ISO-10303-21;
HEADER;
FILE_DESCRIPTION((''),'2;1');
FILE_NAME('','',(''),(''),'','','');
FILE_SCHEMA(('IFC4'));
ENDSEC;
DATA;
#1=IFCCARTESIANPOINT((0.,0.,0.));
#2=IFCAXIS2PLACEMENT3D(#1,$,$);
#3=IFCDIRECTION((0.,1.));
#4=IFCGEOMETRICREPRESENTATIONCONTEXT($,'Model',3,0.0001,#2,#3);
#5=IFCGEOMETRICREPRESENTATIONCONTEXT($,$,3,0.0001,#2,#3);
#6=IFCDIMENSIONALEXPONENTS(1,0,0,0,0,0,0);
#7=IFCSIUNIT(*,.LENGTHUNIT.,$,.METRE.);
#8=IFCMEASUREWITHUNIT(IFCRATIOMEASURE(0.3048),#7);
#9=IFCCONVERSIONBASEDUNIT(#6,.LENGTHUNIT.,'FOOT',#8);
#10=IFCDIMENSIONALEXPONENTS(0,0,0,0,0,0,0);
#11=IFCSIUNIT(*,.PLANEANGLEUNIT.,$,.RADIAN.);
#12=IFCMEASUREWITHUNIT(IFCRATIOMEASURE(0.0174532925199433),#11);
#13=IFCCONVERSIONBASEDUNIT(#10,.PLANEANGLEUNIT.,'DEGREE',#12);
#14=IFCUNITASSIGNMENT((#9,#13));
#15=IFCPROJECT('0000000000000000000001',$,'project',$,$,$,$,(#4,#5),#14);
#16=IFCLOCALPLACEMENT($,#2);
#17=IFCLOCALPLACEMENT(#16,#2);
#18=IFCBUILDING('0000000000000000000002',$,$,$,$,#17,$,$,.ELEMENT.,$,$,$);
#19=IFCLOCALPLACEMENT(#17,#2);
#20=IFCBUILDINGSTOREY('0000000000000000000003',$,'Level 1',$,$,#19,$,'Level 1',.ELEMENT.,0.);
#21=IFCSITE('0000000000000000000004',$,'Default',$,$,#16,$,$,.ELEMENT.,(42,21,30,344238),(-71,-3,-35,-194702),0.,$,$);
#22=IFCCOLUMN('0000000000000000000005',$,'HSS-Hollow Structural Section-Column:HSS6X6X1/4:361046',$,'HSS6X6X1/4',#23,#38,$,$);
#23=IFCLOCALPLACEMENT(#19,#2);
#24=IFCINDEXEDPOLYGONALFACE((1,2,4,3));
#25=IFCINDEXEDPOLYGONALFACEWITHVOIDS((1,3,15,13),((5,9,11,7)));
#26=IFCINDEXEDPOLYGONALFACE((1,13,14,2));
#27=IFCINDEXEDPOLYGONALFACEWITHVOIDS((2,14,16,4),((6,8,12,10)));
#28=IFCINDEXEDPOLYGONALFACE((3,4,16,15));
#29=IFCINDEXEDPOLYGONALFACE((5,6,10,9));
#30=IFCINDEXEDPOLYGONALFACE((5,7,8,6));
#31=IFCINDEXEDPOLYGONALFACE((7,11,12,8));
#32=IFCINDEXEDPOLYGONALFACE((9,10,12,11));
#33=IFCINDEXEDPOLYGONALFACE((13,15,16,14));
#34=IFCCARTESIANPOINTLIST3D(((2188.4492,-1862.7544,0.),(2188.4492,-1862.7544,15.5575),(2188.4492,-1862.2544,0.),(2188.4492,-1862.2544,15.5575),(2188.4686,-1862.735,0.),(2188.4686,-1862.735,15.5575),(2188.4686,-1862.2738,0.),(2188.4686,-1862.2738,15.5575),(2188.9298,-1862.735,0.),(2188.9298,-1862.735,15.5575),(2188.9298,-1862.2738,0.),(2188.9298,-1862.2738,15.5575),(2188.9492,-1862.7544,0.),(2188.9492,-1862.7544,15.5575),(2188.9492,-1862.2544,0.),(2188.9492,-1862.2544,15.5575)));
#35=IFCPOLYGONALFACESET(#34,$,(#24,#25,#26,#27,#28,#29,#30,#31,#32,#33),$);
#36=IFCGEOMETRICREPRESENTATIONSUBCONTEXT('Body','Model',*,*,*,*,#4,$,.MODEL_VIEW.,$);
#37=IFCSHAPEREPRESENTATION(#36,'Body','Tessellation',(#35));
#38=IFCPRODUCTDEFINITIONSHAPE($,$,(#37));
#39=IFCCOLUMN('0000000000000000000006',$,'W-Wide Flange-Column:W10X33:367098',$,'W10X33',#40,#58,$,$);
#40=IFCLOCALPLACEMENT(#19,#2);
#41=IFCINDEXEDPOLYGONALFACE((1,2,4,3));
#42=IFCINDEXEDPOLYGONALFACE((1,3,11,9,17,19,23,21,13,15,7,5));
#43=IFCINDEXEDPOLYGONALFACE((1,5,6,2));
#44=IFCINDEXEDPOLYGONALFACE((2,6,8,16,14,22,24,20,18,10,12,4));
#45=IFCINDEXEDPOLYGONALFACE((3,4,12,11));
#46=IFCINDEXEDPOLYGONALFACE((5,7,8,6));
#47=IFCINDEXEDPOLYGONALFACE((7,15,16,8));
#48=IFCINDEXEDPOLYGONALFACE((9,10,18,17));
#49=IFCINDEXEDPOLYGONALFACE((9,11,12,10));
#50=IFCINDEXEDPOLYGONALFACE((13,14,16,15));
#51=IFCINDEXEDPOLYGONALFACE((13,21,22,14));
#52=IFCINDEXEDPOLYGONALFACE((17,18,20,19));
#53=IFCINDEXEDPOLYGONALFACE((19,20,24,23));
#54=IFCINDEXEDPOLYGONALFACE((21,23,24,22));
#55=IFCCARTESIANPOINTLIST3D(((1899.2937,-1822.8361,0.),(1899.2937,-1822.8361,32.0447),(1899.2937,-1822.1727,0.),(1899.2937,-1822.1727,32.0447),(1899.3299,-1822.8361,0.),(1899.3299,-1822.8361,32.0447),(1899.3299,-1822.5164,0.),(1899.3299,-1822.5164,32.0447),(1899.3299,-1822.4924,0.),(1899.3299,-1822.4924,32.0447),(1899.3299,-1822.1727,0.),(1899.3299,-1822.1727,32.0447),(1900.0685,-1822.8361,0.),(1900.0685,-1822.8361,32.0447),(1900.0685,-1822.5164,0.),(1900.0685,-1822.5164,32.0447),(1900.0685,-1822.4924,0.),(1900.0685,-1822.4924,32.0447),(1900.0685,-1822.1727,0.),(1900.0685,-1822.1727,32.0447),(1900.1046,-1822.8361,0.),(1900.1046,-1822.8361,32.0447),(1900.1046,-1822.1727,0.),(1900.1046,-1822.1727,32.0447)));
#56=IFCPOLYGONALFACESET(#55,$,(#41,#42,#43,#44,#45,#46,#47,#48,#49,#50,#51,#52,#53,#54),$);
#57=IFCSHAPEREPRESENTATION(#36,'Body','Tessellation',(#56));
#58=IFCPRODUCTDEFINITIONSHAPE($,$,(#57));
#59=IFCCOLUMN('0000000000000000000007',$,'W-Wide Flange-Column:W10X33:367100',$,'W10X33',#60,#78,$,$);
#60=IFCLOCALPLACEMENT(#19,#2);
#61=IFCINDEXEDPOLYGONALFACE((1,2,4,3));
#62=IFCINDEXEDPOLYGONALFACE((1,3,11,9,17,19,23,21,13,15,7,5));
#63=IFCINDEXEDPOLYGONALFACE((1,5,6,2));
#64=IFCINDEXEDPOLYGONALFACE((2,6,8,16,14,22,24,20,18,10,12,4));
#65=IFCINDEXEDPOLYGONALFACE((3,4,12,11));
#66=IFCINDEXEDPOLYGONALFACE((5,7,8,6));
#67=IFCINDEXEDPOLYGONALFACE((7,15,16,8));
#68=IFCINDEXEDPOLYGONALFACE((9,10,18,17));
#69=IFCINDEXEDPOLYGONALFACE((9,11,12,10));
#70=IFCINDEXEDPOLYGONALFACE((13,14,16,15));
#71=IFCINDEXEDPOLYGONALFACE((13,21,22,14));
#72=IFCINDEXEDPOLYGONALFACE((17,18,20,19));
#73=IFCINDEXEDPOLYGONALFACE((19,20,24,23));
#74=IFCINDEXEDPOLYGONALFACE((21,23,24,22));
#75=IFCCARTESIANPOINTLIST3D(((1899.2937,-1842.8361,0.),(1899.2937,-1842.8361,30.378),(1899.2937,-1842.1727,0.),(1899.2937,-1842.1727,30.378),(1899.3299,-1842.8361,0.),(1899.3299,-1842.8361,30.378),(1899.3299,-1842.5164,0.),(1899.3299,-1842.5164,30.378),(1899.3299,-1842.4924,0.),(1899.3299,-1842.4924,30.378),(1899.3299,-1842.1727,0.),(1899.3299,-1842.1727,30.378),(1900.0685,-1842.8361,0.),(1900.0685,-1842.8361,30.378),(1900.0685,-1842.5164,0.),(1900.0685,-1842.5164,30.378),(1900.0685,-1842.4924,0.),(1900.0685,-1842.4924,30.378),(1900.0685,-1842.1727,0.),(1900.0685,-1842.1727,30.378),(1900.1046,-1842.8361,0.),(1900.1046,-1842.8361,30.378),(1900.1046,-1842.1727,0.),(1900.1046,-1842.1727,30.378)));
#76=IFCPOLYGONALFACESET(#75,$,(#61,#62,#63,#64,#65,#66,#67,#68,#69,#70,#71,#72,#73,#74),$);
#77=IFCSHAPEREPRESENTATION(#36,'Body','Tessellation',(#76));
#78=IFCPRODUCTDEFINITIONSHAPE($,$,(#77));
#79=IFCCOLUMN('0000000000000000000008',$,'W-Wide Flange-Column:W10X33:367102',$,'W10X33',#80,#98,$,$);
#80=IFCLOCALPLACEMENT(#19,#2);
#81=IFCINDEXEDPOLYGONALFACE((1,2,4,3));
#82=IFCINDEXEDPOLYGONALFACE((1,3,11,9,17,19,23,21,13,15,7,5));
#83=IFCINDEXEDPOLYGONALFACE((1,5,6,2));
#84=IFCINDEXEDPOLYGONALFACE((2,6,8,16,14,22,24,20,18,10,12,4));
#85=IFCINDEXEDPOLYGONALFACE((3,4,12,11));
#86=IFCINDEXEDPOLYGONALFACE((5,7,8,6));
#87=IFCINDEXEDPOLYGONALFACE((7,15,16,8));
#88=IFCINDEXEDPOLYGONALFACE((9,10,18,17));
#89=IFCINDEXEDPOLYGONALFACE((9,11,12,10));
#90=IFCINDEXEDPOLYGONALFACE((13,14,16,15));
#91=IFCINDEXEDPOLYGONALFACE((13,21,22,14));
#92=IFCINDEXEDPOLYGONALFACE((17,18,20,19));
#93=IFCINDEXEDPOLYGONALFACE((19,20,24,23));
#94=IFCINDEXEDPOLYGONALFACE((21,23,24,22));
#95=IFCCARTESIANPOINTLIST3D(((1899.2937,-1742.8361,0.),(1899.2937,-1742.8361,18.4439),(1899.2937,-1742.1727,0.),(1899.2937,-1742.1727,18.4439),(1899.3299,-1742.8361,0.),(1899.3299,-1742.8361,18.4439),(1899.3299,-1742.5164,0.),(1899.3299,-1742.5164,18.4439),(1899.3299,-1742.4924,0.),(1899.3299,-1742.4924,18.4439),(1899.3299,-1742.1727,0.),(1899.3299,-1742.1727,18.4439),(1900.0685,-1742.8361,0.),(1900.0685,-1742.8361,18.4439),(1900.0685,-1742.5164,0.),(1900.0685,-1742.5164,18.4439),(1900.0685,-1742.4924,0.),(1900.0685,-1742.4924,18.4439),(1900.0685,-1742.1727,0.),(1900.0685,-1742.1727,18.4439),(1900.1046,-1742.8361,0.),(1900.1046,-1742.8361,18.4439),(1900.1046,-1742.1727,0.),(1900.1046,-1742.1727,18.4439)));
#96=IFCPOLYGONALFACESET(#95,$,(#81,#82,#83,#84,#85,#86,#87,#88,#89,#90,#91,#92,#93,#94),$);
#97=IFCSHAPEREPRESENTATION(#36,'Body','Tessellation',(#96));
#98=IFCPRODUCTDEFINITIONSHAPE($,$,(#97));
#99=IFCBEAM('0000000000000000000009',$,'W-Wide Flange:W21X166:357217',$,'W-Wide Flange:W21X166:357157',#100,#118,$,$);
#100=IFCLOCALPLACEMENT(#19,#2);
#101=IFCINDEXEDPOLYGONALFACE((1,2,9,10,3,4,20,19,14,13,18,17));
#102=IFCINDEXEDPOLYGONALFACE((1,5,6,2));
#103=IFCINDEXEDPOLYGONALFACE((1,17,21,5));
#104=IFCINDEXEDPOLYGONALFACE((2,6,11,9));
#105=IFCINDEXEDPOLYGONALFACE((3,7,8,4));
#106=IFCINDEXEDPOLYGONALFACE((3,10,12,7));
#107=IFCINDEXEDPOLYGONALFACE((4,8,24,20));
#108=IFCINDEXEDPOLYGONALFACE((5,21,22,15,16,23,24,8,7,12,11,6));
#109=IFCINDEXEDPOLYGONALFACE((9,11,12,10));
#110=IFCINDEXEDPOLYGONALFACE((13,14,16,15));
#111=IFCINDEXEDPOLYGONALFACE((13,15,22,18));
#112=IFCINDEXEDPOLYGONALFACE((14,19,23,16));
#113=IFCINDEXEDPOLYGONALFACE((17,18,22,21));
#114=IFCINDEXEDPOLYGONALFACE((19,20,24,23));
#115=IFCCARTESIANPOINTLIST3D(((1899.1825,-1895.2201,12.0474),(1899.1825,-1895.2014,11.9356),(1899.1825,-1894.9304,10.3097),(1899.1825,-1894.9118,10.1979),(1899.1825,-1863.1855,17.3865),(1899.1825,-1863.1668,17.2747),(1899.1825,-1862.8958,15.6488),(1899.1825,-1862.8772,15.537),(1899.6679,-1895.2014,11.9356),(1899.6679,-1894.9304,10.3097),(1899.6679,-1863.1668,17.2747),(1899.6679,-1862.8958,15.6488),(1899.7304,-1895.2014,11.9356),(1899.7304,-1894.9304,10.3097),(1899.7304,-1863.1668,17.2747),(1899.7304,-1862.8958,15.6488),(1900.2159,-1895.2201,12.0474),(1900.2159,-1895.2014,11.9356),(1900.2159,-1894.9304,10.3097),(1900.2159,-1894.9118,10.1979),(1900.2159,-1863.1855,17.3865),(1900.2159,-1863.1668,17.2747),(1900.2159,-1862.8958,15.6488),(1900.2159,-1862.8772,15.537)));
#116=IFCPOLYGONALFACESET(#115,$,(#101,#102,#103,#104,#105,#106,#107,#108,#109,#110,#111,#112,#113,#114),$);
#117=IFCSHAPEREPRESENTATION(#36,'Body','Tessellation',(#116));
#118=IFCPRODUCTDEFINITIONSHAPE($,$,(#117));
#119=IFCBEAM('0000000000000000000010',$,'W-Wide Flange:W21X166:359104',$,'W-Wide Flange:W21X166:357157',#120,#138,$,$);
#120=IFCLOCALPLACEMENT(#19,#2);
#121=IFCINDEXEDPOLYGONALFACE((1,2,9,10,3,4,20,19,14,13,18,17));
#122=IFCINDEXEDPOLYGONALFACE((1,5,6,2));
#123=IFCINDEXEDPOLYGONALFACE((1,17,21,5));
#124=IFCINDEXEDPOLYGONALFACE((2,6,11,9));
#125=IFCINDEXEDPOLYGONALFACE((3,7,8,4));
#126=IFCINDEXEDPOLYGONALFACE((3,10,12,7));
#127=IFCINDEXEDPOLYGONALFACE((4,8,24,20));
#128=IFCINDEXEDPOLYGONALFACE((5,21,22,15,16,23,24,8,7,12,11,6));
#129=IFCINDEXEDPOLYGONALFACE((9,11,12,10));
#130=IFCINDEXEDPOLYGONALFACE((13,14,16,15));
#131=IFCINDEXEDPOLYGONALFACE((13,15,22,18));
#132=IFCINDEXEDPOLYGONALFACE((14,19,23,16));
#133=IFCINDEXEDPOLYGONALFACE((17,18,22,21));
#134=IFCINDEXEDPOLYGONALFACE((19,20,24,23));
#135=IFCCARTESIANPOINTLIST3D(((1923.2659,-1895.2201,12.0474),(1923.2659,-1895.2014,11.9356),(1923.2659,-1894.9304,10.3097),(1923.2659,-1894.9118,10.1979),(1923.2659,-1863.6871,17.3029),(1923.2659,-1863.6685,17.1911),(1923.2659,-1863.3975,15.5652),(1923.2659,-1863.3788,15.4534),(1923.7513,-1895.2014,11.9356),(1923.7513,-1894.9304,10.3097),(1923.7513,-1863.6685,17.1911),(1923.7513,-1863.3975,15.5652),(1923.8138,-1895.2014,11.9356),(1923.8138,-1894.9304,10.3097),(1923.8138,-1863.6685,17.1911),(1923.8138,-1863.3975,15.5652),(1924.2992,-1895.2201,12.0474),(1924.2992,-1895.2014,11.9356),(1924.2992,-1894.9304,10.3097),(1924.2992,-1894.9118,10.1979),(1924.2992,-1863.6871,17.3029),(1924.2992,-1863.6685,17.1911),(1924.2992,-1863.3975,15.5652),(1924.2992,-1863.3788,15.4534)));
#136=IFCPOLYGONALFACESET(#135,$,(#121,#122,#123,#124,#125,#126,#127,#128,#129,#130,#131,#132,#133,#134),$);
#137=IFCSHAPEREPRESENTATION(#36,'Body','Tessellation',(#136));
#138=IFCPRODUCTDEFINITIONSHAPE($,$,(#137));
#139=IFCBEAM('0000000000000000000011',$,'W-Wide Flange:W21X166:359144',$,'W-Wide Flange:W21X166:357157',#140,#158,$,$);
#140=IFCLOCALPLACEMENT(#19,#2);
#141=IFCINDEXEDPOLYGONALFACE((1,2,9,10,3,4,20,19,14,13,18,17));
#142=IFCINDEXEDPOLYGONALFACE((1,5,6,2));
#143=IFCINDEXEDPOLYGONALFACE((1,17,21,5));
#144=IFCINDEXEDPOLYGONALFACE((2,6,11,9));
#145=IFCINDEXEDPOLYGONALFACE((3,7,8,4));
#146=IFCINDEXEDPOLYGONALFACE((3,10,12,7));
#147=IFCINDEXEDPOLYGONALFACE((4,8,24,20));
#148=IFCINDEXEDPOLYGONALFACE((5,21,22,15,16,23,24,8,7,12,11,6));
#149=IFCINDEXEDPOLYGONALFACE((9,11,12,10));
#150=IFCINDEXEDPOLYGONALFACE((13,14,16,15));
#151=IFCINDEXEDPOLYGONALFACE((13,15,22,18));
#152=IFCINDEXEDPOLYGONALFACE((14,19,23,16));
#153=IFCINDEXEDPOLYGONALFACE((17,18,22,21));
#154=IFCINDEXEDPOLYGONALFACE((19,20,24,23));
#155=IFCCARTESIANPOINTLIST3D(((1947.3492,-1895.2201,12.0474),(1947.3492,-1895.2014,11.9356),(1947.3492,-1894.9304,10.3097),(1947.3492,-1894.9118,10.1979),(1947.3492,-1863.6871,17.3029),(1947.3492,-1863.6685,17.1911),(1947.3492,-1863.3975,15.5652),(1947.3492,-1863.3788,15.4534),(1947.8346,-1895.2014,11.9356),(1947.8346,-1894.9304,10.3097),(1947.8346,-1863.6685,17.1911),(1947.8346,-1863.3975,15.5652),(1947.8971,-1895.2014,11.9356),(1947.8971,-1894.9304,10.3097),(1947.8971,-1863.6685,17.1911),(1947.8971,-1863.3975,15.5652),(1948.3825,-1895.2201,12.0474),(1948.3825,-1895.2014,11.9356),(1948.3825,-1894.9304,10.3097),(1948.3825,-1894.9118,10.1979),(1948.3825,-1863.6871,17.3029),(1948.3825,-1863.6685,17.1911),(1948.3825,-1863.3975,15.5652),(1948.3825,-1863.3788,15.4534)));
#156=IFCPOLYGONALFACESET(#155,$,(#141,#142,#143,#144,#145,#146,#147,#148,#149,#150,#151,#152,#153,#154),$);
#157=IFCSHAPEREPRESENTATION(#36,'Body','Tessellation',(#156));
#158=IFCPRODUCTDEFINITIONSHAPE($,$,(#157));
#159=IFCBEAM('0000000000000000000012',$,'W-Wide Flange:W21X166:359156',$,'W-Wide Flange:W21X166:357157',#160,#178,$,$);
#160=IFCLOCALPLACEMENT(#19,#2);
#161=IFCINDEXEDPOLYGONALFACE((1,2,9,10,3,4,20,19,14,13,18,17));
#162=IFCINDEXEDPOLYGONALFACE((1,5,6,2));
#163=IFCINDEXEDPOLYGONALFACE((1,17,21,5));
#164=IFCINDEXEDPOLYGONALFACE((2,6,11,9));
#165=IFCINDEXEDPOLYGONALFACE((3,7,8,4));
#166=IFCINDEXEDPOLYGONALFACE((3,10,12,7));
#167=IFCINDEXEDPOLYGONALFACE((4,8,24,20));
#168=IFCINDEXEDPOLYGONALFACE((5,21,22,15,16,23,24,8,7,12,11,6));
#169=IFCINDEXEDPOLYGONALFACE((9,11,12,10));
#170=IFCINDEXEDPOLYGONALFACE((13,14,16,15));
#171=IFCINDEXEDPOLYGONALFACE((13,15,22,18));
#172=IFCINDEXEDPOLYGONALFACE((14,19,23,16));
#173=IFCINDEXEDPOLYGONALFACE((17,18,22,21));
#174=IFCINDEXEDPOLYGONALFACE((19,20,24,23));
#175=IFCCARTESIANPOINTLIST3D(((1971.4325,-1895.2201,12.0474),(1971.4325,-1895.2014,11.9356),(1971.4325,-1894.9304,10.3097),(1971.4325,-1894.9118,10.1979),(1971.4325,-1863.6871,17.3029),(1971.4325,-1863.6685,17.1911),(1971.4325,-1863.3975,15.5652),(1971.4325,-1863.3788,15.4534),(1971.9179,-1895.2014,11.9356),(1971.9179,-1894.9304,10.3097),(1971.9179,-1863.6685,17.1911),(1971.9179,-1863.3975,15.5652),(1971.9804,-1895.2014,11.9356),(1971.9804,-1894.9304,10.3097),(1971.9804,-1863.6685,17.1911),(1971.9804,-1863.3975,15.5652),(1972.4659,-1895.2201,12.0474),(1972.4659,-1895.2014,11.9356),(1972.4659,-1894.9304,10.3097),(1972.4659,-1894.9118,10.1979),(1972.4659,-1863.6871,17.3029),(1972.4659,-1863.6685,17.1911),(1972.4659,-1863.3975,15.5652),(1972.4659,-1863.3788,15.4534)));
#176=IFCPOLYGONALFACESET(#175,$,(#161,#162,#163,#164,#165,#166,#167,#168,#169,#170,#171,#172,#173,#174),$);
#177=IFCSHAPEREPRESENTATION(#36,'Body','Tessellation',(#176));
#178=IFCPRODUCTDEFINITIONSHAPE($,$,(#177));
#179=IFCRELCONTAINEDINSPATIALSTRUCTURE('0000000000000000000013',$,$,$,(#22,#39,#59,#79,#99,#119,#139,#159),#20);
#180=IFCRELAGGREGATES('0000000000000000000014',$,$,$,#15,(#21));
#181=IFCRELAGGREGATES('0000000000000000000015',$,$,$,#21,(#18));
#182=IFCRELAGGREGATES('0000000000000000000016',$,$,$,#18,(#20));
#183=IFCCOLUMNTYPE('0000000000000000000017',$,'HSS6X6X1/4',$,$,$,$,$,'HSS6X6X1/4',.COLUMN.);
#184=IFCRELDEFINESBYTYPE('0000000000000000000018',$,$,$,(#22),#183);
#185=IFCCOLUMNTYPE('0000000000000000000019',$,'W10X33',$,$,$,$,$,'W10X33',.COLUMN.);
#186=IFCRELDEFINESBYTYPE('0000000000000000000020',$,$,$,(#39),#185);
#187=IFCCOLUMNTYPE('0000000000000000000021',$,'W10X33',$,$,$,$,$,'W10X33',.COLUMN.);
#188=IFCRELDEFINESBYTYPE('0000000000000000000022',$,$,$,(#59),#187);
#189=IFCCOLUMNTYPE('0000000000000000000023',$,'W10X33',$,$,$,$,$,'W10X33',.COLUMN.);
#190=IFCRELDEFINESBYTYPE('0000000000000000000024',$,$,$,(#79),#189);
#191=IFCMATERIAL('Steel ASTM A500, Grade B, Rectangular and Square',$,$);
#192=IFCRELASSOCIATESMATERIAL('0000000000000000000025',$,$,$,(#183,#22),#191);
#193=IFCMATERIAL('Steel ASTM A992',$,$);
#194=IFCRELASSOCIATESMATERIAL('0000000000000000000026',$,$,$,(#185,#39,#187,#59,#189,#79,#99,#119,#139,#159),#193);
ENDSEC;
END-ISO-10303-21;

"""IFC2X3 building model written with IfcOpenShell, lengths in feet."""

from ifc_helpers import new_model, entity, si_unit, converted_unit, direction, frame, frame_2d, origin, place, context, subcontext, project, spatial, polyline, i_section, outline, extrude, source, transform, mapped, material, type_object, type_shapes, element, save


model = new_model("IFC2X3")

# Units and contexts
model_context = context("Model", 3, precision=0.0001, world=origin(), true_north=direction((0.0, 1.0)))
context_of_model = context(None, 3, precision=0.0001, world=origin(), true_north=direction((0.0, 1.0)))
body_context = subcontext(model_context, "Body", "Model", "MODEL_VIEW")
ifc_project = project(units=[converted_unit("LENGTHUNIT", "FOOT", entity("IfcRatioMeasure", 0.3048), si_unit("LENGTHUNIT", "METRE"), dimensions=[1, 0, 0, 0, 0, 0, 0]), converted_unit("PLANEANGLEUNIT", "DEGREE", entity("IfcRatioMeasure", 0.0174532925199433), si_unit("PLANEANGLEUNIT", "RADIAN"), dimensions=[0, 0, 0, 0, 0, 0, 0])], contexts=[model_context, context_of_model])

# Site, building, storey
site_placement = place(None, origin())
site = spatial("IfcSite", under=ifc_project, at=site_placement, Name="Default", CompositionType="ELEMENT", RefLatitude=(42, 21, 30, 344238), RefLongitude=(-71, -3, -35, -194702), RefElevation=0.0)
building_placement = place(site_placement, origin())
building = spatial("IfcBuilding", under=site, at=building_placement, CompositionType="ELEMENT")
storey_placement = place(building_placement, origin())
storey = spatial("IfcBuildingStorey", under=building, at=storey_placement, Name="Level 1", LongName="Level 1", CompositionType="ELEMENT", Elevation=0.0)

# Columns
ifc_material_1 = material(Name="Steel ASTM A500, Grade B, Rectangular and Square")
column_type_1 = type_object("IfcColumnType", Name="HSS6X6X1/4", ElementType="HSS6X6X1/4", PredefinedType="COLUMN", material=ifc_material_1)
shared_shape_1 = source(origin(), body_context, "Body", "SweptSolid", [
    extrude(outline(polyline([(-0.25, -0.25), (0.25, -0.25), (0.25, 0.25), (-0.25, 0.25), (-0.25, -0.25)]), holes=[polyline([(-0.2306, -0.2306), (-0.2306, 0.2306), (0.2306, 0.2306), (0.2306, -0.2306), (-0.2306, -0.2306)])]), frame((0.25, 0.25, 0.0), z_axis=(0.0, 0.0, 1.0), x_axis=(-1.0, 0.0, 0.0)), (0.0, 0.0, 1.0), 15.5575),
])
type_shapes(column_type_1, [shared_shape_1])
column_1_placement = place(storey_placement, frame((2188.4492, -1862.7544, 0.0)))
element("IfcColumn", 1, at=column_1_placement, inside=storey, type_object=column_type_1, material=ifc_material_1, Name="HSS-Hollow Structural Section-Column:HSS6X6X1/4:361046", ObjectType="HSS6X6X1/4", context=body_context, shape_type="MappedRepresentation", body=[
    mapped(shared_shape_1, transform((0.0, 0.0, 0.0), scale=1.0)),
])
ifc_material_2 = material(Name="Steel ASTM A992")
column_type_2 = type_object("IfcColumnType", Name="W10X33", ElementType="W10X33", PredefinedType="COLUMN", material=ifc_material_2)
shared_shape_2 = source(origin(), body_context, "Body", "SweptSolid", [
    extrude(i_section(OverallWidth=0.6634, OverallDepth=0.8109, WebThickness=0.0241, FlangeThickness=0.0361, at=frame_2d((0.0, 0.0), x_axis=(1.0, 0.0))), frame((0.4054, 0.3317, 0.0), z_axis=(0.0, 0.0, 1.0), x_axis=(0.0, 1.0, 0.0)), (0.0, 0.0, 1.0), 32.0447),
])
type_shapes(column_type_2, [shared_shape_2])
column_2_placement = place(storey_placement, frame((1899.2937, -1822.8361, 0.0)))
element("IfcColumn", 2, at=column_2_placement, inside=storey, type_object=column_type_2, material=ifc_material_2, Name="W-Wide Flange-Column:W10X33:367098", ObjectType="W10X33", context=body_context, shape_type="MappedRepresentation", body=[
    mapped(shared_shape_2, transform((0.0, 0.0, 0.0), scale=1.0)),
])
column_type_3 = type_object("IfcColumnType", Name="W10X33", ElementType="W10X33", PredefinedType="COLUMN", material=ifc_material_2)
shared_shape_3 = source(origin(), body_context, "Body", "SweptSolid", [
    extrude(i_section(OverallWidth=0.6634, OverallDepth=0.8109, WebThickness=0.0241, FlangeThickness=0.0361, at=frame_2d((0.0, 0.0), x_axis=(1.0, 0.0))), frame((0.4054, 0.3317, 0.0), z_axis=(0.0, 0.0, 1.0), x_axis=(0.0, 1.0, 0.0)), (0.0, 0.0, 1.0), 30.378),
])
type_shapes(column_type_3, [shared_shape_3])
column_3_placement = place(storey_placement, frame((1899.2937, -1842.8361, 0.0)))
element("IfcColumn", 3, at=column_3_placement, inside=storey, type_object=column_type_3, material=ifc_material_2, Name="W-Wide Flange-Column:W10X33:367100", ObjectType="W10X33", context=body_context, shape_type="MappedRepresentation", body=[
    mapped(shared_shape_3, transform((0.0, 0.0, 0.0), scale=1.0)),
])
column_type_4 = type_object("IfcColumnType", Name="W10X33", ElementType="W10X33", PredefinedType="COLUMN", material=ifc_material_2)
shared_shape_4 = source(origin(), body_context, "Body", "SweptSolid", [
    extrude(i_section(OverallWidth=0.6634, OverallDepth=0.8109, WebThickness=0.0241, FlangeThickness=0.0361, at=frame_2d((0.0, 0.0), x_axis=(1.0, 0.0))), frame((0.4054, 0.3317, 0.0), z_axis=(0.0, 0.0, 1.0), x_axis=(0.0, 1.0, 0.0)), (0.0, 0.0, 1.0), 18.4439),
])
type_shapes(column_type_4, [shared_shape_4])
column_4_placement = place(storey_placement, frame((1899.2937, -1742.8361, 0.0)))
element("IfcColumn", 4, at=column_4_placement, inside=storey, type_object=column_type_4, material=ifc_material_2, Name="W-Wide Flange-Column:W10X33:367102", ObjectType="W10X33", context=body_context, shape_type="MappedRepresentation", body=[
    mapped(shared_shape_4, transform((0.0, 0.0, 0.0), scale=1.0)),
])

# Beams
beam_1_placement = place(storey_placement, frame((1899.6992, -1895.6585, 11.9743), z_axis=(0.0, -0.164399, 0.986394), x_axis=(0.0, 0.986394, 0.164399)))
element("IfcBeam", 5, at=beam_1_placement, inside=storey, material=ifc_material_2, Name="W-Wide Flange:W21X166:357217", ObjectType="W-Wide Flange:W21X166:357157", context=body_context, shape_type="SweptSolid", body=[
    extrude(i_section(OverallWidth=1.0333, OverallDepth=1.875, WebThickness=0.0625, FlangeThickness=0.1133, at=frame_2d((0.0, 0.0), x_axis=(0.0, 1.0))), frame((0.4445, 0.0, -0.9375), z_axis=(1.0, 0.0, 0.0), x_axis=(0.0, 0.0, -1.0)), (0.0, 0.0, 1.0), 32.4765),
])
beam_2_placement = place(storey_placement, frame((1923.7825, -1895.6585, 11.9743), z_axis=(0.0, -0.164399, 0.986394), x_axis=(0.0, 0.986394, 0.164399)))
element("IfcBeam", 6, at=beam_2_placement, inside=storey, material=ifc_material_2, Name="W-Wide Flange:W21X166:359104", ObjectType="W-Wide Flange:W21X166:357157", context=body_context, shape_type="SweptSolid", body=[
    extrude(i_section(OverallWidth=1.0333, OverallDepth=1.875, WebThickness=0.0625, FlangeThickness=0.1133, at=frame_2d((0.0, 0.0), x_axis=(0.0, 1.0))), frame((0.4445, 0.0, -0.9375), z_axis=(1.0, 0.0, 0.0), x_axis=(0.0, 0.0, -1.0)), (0.0, 0.0, 1.0), 31.9679),
])
beam_3_placement = place(storey_placement, frame((1947.8659, -1895.6585, 11.9743), z_axis=(0.0, -0.164399, 0.986394), x_axis=(0.0, 0.986394, 0.164399)))
element("IfcBeam", 7, at=beam_3_placement, inside=storey, material=ifc_material_2, Name="W-Wide Flange:W21X166:359144", ObjectType="W-Wide Flange:W21X166:357157", context=body_context, shape_type="SweptSolid", body=[
    extrude(i_section(OverallWidth=1.0333, OverallDepth=1.875, WebThickness=0.0625, FlangeThickness=0.1133, at=frame_2d((0.0, 0.0), x_axis=(0.0, 1.0))), frame((0.4445, 0.0, -0.9375), z_axis=(1.0, 0.0, 0.0), x_axis=(0.0, 0.0, -1.0)), (0.0, 0.0, 1.0), 31.9679),
])
beam_4_placement = place(storey_placement, frame((1971.9492, -1895.6585, 11.9743), z_axis=(0.0, -0.164399, 0.986394), x_axis=(0.0, 0.986394, 0.164399)))
element("IfcBeam", 8, at=beam_4_placement, inside=storey, material=ifc_material_2, Name="W-Wide Flange:W21X166:359156", ObjectType="W-Wide Flange:W21X166:357157", context=body_context, shape_type="SweptSolid", body=[
    extrude(i_section(OverallWidth=1.0333, OverallDepth=1.875, WebThickness=0.0625, FlangeThickness=0.1133, at=frame_2d((0.0, 0.0), x_axis=(0.0, 1.0))), frame((0.4445, 0.0, -0.9375), z_axis=(1.0, 0.0, 0.0), x_axis=(0.0, 0.0, -1.0)), (0.0, 0.0, 1.0), 31.9679),
])

save(model, "model.ifc")
